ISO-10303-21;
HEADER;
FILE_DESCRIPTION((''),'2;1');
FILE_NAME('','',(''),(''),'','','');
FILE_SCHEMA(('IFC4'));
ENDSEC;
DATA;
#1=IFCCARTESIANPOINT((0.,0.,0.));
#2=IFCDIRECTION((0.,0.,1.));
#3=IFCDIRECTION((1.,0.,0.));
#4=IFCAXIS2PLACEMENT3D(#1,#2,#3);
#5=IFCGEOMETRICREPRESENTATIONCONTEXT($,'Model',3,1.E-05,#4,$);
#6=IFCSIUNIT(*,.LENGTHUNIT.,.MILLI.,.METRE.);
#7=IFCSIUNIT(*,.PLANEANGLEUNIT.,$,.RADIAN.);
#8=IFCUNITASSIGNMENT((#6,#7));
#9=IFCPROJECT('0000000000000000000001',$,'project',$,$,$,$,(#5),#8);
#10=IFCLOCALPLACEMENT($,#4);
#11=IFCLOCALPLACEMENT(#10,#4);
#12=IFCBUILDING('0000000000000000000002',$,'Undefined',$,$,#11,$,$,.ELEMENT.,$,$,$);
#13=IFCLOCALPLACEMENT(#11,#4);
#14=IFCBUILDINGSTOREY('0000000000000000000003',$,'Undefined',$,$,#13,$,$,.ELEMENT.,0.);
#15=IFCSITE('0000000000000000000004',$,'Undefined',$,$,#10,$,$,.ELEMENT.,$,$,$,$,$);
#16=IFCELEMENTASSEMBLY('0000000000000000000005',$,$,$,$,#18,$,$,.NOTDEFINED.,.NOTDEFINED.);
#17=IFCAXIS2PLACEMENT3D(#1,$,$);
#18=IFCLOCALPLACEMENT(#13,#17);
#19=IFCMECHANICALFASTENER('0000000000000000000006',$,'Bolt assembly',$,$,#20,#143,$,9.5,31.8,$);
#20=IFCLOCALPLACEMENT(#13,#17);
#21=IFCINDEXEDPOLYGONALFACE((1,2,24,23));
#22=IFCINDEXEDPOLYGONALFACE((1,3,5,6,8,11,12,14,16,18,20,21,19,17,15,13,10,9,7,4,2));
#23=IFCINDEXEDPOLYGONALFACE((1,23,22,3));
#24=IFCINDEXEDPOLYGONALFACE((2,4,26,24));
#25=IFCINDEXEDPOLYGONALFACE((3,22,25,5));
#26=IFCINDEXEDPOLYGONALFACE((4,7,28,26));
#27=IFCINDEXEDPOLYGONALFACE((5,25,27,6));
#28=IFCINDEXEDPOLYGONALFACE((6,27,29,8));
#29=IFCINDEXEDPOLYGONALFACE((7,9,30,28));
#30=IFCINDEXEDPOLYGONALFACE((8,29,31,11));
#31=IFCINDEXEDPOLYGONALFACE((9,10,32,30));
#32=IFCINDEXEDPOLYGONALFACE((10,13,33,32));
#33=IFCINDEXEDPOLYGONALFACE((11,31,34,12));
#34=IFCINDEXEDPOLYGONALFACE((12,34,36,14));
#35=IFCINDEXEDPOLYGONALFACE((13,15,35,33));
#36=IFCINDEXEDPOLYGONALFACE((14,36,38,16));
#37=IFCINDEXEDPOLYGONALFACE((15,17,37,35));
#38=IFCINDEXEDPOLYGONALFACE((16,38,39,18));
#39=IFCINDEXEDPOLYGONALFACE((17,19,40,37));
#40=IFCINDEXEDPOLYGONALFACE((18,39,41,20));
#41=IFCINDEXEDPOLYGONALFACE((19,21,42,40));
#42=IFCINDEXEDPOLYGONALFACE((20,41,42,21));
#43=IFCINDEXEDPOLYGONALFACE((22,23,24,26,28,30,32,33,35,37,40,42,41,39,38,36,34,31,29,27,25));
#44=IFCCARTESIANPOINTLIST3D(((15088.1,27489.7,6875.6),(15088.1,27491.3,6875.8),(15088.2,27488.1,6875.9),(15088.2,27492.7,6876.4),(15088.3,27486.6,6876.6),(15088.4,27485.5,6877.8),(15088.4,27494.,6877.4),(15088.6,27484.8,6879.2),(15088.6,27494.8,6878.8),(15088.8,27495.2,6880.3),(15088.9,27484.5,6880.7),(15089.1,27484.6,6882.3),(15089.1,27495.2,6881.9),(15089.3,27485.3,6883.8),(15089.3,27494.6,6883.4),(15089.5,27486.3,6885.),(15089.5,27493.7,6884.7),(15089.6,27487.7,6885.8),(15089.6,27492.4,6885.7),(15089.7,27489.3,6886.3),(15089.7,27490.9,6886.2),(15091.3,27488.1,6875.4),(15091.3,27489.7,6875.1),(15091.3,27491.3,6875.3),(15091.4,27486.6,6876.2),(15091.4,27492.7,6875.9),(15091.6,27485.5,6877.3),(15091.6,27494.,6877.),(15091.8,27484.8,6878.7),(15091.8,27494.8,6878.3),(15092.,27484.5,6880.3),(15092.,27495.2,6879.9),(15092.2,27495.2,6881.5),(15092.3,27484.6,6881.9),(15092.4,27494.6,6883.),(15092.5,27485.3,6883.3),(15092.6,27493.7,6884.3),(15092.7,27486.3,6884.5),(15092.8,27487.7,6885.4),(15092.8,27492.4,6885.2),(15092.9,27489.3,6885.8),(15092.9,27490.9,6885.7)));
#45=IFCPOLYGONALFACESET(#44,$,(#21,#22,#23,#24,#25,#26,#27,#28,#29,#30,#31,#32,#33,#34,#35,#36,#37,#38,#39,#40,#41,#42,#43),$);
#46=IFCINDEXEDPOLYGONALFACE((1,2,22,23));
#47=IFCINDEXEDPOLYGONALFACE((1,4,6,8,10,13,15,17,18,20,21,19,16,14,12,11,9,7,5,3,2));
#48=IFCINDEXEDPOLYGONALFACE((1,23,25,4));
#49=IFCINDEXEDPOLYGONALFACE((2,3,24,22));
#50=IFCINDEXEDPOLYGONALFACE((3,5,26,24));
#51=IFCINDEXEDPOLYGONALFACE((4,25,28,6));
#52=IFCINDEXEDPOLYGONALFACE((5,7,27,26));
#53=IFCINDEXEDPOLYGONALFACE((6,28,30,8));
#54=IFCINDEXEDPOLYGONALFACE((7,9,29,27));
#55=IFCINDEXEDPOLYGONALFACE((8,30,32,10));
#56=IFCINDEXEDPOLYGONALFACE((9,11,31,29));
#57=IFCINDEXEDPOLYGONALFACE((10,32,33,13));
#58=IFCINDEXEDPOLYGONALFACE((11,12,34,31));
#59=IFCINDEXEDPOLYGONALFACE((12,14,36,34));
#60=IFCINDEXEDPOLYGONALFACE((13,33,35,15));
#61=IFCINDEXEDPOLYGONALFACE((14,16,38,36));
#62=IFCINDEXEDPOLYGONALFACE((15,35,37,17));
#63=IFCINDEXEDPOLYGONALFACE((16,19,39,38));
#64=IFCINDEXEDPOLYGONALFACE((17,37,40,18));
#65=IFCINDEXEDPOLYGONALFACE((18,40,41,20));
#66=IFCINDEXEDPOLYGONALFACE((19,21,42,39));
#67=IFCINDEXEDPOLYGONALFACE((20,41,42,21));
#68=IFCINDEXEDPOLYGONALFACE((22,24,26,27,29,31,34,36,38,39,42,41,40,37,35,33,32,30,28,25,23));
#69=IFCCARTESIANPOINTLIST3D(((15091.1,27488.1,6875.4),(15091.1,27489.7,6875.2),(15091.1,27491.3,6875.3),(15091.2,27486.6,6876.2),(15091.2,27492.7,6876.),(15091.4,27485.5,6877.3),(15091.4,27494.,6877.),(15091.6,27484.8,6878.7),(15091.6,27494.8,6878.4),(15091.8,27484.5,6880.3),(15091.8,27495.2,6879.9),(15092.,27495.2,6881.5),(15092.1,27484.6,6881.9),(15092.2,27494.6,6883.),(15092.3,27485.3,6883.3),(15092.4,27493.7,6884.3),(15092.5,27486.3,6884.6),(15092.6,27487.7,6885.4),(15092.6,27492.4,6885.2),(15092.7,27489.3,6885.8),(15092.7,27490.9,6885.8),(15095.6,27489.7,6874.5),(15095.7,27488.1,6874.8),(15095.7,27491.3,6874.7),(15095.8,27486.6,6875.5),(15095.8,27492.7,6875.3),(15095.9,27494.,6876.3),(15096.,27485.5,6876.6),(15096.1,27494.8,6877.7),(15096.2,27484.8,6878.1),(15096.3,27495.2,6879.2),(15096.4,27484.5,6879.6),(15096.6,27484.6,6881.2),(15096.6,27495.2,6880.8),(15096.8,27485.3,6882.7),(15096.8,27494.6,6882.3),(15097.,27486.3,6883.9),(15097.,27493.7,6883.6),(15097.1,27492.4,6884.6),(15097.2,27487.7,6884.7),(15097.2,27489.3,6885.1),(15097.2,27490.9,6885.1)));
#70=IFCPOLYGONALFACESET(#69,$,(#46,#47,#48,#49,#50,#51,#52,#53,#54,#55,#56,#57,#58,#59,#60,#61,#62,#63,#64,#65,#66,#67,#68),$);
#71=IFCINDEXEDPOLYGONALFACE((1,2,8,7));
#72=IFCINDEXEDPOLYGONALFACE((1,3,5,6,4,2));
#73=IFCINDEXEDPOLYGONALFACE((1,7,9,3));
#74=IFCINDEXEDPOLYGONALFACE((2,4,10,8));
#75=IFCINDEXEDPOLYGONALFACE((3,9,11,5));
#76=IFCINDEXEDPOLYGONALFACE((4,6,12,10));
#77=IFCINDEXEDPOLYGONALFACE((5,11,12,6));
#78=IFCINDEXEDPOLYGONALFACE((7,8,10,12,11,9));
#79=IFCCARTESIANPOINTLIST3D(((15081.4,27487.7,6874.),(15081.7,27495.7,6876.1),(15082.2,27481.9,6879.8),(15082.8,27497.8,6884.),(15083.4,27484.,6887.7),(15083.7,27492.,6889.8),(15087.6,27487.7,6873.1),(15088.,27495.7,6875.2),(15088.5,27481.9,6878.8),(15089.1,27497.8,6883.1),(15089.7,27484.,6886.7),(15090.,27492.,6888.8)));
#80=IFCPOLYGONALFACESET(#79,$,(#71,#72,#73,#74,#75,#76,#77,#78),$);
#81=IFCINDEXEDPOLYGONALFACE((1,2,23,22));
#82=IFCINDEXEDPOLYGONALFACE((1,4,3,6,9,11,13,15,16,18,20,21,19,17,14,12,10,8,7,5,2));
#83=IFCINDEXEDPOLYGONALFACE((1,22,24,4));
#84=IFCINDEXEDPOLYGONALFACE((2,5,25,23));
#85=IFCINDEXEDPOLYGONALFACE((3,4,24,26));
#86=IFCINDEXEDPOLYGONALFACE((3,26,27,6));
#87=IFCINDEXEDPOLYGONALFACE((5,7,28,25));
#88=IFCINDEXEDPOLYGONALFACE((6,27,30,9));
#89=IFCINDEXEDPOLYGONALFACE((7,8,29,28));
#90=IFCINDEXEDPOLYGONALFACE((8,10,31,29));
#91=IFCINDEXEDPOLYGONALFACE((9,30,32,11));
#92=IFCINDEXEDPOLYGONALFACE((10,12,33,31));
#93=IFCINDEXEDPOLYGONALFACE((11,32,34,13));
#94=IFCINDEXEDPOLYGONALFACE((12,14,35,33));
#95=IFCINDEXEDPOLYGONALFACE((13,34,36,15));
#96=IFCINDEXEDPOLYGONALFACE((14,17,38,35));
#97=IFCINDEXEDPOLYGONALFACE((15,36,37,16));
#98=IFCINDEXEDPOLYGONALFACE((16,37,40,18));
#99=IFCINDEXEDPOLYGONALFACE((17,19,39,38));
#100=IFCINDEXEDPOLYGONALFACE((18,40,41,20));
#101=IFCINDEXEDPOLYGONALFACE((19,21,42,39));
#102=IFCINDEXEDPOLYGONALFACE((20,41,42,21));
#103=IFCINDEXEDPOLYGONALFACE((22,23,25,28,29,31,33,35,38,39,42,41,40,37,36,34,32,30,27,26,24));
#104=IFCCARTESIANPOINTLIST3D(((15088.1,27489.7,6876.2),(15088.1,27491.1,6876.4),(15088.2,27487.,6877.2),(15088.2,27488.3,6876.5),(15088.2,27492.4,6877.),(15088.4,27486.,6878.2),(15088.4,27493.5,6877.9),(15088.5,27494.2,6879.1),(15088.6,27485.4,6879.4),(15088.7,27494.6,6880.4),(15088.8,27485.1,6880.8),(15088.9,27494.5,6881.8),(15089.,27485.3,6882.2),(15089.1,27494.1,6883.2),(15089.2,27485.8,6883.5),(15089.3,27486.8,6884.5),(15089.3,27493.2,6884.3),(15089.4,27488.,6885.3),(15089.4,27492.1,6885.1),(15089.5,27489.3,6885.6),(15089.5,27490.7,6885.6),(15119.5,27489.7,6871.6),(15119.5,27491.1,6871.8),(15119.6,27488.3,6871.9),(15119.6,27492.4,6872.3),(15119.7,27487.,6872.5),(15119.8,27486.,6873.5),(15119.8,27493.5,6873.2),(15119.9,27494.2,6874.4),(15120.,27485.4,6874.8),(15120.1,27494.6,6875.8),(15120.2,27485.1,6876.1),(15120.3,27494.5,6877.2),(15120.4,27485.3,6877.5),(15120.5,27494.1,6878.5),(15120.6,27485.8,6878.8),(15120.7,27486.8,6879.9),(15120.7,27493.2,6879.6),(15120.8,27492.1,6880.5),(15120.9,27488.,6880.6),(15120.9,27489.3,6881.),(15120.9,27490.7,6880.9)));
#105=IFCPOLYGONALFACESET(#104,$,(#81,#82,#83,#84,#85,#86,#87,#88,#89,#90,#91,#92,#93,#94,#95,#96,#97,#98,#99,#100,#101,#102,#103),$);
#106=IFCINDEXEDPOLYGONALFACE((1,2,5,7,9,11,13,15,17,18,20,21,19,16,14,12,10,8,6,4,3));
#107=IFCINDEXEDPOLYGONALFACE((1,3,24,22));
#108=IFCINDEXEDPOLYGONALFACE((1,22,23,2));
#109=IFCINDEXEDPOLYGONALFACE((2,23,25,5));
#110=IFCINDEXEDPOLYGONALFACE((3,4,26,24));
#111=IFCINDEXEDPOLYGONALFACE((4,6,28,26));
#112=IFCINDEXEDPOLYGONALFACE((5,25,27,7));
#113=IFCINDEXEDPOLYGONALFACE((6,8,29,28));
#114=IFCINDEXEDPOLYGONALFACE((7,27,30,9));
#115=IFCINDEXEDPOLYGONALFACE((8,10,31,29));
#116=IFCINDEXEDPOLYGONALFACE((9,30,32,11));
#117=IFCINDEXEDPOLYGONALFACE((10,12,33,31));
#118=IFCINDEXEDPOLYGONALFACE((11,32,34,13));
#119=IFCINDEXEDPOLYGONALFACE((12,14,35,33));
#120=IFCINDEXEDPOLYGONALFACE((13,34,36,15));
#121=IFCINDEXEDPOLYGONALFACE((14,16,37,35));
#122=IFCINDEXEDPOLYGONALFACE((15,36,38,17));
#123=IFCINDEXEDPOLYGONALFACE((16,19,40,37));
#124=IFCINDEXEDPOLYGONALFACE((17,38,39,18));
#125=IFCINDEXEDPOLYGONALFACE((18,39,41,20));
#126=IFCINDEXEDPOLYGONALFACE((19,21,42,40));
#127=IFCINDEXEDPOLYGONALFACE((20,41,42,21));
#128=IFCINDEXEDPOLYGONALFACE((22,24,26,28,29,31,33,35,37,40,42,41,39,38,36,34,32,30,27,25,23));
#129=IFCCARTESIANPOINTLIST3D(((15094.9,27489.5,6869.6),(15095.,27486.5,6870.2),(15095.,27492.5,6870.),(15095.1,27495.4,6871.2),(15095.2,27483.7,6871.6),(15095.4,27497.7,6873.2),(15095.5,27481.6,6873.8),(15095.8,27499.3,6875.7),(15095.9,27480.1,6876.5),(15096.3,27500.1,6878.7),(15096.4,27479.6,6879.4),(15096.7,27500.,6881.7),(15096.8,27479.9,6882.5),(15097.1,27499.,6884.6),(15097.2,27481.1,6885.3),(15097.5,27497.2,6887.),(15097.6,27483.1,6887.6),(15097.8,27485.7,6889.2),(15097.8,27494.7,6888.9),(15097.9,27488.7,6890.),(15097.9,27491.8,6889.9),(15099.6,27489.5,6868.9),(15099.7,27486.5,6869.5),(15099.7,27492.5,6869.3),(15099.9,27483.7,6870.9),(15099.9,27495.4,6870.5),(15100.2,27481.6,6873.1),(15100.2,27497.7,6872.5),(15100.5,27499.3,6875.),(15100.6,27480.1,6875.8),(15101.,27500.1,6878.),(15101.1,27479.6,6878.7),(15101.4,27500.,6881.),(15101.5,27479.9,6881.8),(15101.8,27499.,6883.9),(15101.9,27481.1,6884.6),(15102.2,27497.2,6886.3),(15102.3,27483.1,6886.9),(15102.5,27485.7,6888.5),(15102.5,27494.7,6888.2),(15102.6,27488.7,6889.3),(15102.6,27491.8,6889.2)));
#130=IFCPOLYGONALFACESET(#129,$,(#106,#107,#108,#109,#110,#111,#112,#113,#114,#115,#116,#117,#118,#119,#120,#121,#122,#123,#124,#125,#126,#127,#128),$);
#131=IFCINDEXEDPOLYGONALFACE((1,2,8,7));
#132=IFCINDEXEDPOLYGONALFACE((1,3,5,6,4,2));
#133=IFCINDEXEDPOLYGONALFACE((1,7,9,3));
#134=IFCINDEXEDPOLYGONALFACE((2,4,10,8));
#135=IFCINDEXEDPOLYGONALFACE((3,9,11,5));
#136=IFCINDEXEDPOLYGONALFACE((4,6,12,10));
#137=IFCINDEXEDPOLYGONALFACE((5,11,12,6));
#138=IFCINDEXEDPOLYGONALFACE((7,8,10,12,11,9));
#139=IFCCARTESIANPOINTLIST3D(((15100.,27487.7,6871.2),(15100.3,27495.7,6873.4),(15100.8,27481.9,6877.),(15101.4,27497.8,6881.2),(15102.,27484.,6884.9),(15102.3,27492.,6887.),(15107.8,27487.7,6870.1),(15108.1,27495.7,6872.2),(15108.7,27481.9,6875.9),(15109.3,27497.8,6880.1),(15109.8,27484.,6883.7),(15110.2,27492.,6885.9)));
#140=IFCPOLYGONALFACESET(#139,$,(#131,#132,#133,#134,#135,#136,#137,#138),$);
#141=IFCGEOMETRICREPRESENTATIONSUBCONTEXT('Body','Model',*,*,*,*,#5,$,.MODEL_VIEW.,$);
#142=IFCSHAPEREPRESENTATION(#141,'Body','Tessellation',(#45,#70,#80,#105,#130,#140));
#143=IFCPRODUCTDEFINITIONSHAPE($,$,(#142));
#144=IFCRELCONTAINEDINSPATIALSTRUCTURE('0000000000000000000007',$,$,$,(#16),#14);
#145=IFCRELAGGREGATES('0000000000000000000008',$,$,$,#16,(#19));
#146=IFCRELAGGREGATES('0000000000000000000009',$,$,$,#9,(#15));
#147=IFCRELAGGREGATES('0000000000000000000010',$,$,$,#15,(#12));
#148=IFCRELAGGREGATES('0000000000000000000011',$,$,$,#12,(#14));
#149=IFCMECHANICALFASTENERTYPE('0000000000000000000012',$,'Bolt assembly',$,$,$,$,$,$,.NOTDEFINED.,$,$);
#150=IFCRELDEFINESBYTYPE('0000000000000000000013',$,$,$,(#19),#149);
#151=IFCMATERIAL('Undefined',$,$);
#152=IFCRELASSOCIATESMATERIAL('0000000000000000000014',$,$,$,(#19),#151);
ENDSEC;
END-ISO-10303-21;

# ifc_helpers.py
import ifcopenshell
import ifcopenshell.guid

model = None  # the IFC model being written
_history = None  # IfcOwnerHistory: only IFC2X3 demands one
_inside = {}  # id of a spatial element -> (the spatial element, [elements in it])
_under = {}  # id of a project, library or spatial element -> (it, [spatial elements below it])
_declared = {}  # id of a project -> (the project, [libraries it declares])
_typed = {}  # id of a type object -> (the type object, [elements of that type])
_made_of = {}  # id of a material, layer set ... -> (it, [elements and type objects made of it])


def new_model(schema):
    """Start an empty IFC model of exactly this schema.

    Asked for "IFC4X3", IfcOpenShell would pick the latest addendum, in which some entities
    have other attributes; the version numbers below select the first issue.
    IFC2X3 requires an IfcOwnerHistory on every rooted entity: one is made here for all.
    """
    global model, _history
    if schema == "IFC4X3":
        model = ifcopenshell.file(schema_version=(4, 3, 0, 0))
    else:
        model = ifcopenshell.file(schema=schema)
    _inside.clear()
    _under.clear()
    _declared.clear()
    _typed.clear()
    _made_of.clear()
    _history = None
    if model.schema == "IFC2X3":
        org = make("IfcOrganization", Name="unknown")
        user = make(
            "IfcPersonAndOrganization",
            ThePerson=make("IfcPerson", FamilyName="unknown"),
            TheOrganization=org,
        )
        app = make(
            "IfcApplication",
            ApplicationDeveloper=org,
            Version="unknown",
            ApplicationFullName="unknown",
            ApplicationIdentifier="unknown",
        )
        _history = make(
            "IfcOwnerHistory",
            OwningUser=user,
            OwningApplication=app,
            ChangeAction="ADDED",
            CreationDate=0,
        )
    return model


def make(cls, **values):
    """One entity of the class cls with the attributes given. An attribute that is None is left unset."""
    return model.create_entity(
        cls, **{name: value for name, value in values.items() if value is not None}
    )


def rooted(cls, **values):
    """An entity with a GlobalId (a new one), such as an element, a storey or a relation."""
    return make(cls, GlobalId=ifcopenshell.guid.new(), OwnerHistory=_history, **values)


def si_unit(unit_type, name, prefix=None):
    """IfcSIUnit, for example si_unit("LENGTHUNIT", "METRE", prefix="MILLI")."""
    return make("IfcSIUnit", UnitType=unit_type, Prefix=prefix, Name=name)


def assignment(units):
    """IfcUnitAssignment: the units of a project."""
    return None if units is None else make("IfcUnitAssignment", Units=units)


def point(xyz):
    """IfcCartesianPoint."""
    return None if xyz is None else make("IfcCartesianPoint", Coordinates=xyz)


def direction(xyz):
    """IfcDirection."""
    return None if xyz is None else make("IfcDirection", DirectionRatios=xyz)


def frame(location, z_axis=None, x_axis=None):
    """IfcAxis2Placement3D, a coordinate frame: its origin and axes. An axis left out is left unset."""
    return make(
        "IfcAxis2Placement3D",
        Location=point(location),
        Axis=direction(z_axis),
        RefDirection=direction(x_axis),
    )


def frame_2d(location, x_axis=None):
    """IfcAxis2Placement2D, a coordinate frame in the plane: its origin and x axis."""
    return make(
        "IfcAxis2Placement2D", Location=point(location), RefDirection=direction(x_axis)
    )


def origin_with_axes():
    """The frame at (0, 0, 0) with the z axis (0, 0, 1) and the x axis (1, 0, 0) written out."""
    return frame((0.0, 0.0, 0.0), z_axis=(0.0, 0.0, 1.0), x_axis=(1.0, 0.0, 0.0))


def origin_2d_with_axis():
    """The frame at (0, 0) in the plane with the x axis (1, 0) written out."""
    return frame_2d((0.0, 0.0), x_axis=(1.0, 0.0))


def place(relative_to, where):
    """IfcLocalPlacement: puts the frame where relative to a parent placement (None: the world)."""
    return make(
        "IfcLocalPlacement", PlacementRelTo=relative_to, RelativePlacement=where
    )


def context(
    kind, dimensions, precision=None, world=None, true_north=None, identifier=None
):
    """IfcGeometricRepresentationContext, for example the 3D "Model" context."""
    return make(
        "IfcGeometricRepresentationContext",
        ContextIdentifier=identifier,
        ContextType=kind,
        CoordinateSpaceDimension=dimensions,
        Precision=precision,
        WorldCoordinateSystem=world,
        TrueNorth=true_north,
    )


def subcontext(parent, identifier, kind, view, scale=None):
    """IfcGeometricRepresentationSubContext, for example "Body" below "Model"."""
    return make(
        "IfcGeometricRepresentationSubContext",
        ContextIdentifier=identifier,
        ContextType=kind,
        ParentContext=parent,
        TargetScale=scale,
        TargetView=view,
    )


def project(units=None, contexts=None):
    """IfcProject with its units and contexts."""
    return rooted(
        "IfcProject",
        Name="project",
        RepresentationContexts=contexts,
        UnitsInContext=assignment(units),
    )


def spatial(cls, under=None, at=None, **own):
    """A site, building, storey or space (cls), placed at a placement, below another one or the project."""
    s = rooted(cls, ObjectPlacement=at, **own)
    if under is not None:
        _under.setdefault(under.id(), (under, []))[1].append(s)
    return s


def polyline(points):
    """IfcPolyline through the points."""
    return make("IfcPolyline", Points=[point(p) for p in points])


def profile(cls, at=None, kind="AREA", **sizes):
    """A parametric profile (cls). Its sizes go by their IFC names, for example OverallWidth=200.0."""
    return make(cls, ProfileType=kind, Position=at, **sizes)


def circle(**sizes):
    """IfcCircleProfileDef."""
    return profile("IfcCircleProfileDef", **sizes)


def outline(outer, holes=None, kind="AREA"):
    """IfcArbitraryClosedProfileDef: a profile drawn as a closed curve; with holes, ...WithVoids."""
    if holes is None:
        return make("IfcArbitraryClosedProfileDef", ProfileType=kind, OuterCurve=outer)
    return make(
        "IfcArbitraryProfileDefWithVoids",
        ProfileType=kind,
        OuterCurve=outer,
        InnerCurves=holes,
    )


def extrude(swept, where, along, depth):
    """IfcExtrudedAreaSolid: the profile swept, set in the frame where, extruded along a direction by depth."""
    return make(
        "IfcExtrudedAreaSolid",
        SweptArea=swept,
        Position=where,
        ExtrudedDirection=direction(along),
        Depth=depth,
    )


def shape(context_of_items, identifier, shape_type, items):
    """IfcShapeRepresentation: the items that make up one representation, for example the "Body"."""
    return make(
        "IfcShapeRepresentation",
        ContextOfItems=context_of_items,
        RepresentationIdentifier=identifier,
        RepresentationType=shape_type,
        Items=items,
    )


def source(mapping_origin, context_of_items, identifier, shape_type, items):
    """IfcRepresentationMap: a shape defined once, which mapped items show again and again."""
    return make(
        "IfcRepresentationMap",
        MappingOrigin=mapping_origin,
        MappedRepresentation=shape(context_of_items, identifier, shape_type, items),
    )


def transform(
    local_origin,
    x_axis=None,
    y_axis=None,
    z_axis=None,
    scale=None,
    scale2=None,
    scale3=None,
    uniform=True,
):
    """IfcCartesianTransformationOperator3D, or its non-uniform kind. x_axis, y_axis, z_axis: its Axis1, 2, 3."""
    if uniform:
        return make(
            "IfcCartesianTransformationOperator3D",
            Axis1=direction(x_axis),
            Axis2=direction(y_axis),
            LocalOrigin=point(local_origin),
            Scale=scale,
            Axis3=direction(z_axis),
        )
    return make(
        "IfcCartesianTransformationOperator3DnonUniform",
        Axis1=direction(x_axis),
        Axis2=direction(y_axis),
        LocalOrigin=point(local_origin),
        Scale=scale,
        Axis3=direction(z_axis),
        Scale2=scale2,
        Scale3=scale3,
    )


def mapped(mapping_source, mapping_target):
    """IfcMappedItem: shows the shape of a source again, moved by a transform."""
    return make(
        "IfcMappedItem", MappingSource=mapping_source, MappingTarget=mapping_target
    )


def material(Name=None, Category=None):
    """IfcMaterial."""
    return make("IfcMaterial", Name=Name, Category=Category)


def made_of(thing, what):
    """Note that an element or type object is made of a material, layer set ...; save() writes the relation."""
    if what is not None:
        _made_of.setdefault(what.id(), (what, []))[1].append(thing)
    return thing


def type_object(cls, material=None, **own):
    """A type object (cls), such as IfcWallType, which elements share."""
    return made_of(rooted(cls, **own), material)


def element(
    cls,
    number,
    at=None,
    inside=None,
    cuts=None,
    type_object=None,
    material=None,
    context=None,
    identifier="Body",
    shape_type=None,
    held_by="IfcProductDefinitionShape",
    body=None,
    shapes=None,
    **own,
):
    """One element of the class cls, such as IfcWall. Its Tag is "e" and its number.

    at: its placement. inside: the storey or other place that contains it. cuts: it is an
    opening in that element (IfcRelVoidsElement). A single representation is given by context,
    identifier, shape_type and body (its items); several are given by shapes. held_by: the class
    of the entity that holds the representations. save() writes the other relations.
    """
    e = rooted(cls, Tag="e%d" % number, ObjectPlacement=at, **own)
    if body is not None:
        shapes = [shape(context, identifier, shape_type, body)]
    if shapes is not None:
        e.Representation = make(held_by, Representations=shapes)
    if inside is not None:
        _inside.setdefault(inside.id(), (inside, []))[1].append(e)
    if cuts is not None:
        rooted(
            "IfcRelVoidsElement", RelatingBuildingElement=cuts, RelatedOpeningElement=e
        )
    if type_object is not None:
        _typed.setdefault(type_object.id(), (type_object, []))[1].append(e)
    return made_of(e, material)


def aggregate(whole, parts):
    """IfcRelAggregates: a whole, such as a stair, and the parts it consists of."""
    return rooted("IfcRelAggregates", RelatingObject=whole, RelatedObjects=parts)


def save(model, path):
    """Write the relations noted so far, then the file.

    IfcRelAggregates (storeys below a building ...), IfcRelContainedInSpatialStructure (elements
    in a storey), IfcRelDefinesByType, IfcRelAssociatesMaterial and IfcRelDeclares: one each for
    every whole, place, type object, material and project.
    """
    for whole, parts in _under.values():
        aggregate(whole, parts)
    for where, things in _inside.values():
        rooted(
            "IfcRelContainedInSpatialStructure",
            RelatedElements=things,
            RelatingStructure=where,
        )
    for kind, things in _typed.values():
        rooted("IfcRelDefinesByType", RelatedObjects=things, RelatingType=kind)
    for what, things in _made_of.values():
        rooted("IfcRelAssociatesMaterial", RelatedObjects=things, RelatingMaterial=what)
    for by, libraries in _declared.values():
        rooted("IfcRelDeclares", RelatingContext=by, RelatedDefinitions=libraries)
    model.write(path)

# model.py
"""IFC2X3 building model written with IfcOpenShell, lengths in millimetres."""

from ifc_helpers import new_model, si_unit, frame, origin_with_axes, origin_2d_with_axis, place, context, subcontext, project, spatial, polyline, circle, outline, extrude, source, transform, mapped, material, type_object, element, aggregate, save


model = new_model("IFC2X3")

# Units and contexts
model_context = context("Model", 3, precision=1e-05, world=origin_with_axes())
body_context = subcontext(model_context, "Body", "Model", "MODEL_VIEW")
ifc_project = project(units=[si_unit("LENGTHUNIT", "METRE", prefix="MILLI"), si_unit("PLANEANGLEUNIT", "RADIAN")], contexts=[model_context])

# Site, building, storey
site_placement = place(None, origin_with_axes())
site = spatial("IfcSite", under=ifc_project, at=site_placement, Name="Undefined", CompositionType="ELEMENT")
building_placement = place(site_placement, origin_with_axes())
building = spatial("IfcBuilding", under=site, at=building_placement, Name="Undefined", CompositionType="ELEMENT")
storey_placement = place(building_placement, origin_with_axes())
storey = spatial("IfcBuildingStorey", under=building, at=storey_placement, Name="Undefined", CompositionType="ELEMENT", Elevation=0.0)

# Element assembly
assembly_1_placement = place(storey_placement, origin_with_axes())
assembly_1 = element("IfcElementAssembly", 1, at=assembly_1_placement, inside=storey, AssemblyPlace="NOTDEFINED", PredefinedType="NOTDEFINED")

# Shared definitions
ifc_material_1 = material(Name="Undefined")
mechanical_fastener_type = type_object("IfcMechanicalFastenerType", Name="Bolt assembly")

# Mechanical fastener
shared_shape_1 = source(origin_with_axes(), body_context, "Body", "SweptSolid", [
    extrude(circle(Radius=5.4, at=origin_2d_with_axis()), frame((0.0, -3.1, 0.0), z_axis=(0.0, 1.0, 0.0), x_axis=(1.0, 0.0, 0.0)), (0.0, 0.0, 1.0), 3.2),
    extrude(circle(Radius=5.4, at=origin_2d_with_axis()), frame((0.0, -0.1, 0.0), z_axis=(0.0, 1.0, 0.0), x_axis=(1.0, 0.0, 0.0)), (0.0, 0.0, 1.0), 4.6),
    extrude(outline(polyline([(7.1, -4.1), (7.1, 4.1), (0.0, 8.2), (-7.1, 4.1), (-7.1, -4.1), (0.0, -8.2), (7.1, -4.1)])), frame((0.0, -9.6, 0.0), z_axis=(0.0, 1.0, 0.0), x_axis=(1.0, 0.0, 0.0)), (0.0, 0.0, 1.0), 6.3),
    extrude(circle(Radius=4.8, at=origin_2d_with_axis()), frame((0.0, -3.2, 0.0), z_axis=(0.0, 1.0, 0.0), x_axis=(1.0, 0.0, 0.0)), (0.0, 0.0, 1.0), 31.8),
    extrude(circle(Radius=10.3, at=origin_2d_with_axis()), frame((0.0, 4.5, 0.0), z_axis=(0.0, 1.0, 0.0), x_axis=(1.0, 0.0, 0.0)), (0.0, 0.0, 1.0), 4.8),
    extrude(outline(polyline([(7.1, -4.1), (7.1, 4.1), (0.0, 8.2), (-7.1, 4.1), (-7.1, -4.1), (0.0, -8.2), (7.1, -4.1)])), frame((0.0, 9.3, 0.0), z_axis=(0.0, 1.0, 0.0), x_axis=(1.0, 0.0, 0.0)), (0.0, 0.0, 1.0), 7.9),
])
mechanical_fastener_1_placement = place(assembly_1_placement, frame((15092.0, 27489.9, 6880.5), z_axis=(-0.10338, 0.707107, -0.699509), x_axis=(0.10338, 0.707107, 0.699509)))
mechanical_fastener_1 = element("IfcMechanicalFastener", 2, at=mechanical_fastener_1_placement, type_object=mechanical_fastener_type, material=ifc_material_1, Name="Bolt assembly", NominalDiameter=9.5, NominalLength=31.8, context=body_context, shape_type="MappedRepresentation", body=[
    mapped(shared_shape_1, transform((0.0, 0.0, 0.0))),
])
aggregate(assembly_1, [mechanical_fastener_1])

save(model, "model.ifc")
